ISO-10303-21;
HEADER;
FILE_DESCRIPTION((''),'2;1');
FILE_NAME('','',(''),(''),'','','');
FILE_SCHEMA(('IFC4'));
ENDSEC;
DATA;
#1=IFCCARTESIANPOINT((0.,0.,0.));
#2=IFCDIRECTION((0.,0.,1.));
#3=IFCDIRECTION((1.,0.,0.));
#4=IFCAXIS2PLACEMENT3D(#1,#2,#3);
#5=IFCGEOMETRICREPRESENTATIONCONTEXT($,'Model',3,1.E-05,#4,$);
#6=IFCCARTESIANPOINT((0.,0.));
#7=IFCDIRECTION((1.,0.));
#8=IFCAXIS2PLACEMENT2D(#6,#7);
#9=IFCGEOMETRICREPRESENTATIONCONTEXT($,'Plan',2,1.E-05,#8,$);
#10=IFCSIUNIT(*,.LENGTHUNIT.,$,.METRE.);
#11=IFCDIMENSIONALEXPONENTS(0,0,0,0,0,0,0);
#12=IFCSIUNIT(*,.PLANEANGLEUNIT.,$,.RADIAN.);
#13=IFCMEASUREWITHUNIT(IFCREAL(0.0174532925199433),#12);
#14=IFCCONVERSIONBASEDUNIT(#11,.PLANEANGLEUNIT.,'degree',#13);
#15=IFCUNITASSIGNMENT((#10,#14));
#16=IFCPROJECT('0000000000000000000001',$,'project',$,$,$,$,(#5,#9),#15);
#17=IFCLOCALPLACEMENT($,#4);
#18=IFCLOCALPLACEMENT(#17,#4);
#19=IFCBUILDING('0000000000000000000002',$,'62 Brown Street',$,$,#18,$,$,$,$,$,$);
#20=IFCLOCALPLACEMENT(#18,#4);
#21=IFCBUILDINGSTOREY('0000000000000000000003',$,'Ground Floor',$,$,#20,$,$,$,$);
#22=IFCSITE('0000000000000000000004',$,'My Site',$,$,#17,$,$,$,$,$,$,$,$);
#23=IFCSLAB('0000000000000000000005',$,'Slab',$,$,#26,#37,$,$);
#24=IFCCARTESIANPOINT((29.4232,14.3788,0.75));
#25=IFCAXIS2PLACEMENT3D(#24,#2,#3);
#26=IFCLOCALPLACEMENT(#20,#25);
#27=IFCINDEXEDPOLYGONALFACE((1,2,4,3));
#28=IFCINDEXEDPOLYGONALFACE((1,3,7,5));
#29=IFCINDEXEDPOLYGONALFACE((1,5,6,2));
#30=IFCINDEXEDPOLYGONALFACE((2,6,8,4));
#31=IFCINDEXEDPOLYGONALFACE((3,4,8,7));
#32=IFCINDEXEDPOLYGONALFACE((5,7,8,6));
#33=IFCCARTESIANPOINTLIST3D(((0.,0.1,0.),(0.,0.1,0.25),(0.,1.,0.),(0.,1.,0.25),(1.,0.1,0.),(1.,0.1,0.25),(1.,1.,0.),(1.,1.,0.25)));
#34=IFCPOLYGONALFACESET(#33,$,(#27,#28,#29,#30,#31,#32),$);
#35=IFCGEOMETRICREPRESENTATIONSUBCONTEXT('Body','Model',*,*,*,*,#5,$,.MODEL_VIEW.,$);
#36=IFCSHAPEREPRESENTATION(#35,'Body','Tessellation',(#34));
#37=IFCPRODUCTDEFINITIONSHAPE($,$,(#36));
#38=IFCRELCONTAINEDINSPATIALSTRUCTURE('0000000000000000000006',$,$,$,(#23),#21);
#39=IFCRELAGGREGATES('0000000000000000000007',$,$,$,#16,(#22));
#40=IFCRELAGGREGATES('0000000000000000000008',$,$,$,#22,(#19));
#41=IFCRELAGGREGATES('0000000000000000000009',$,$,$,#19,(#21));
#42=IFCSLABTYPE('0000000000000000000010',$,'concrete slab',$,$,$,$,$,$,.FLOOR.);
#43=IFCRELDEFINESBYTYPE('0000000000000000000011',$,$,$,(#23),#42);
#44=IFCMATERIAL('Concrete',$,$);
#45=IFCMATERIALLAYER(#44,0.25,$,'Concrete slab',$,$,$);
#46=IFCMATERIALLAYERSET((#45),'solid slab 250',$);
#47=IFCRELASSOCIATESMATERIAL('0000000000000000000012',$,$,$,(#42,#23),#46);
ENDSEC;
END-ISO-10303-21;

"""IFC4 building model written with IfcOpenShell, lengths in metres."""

from ifc_helpers import new_model, entity, si_unit, converted_unit, frame, origin_with_axes, origin_2d_with_axis, place, context, subcontext, project, spatial, line, indexed_curve, outline, extrude, material, layer, layer_set, layer_usage, type_object, element, save


model = new_model("IFC4")

# Units and contexts
model_context = context("Model", 3, precision=1e-05, world=origin_with_axes())
plan_context = context("Plan", 2, precision=1e-05, world=origin_2d_with_axis())
body_context_1 = subcontext(model_context, "Body", "Model", "MODEL_VIEW")
ifc_project = project(units=[si_unit("LENGTHUNIT", "METRE"), converted_unit("PLANEANGLEUNIT", "degree", entity("IfcReal", 0.0174532925199433), si_unit("PLANEANGLEUNIT", "RADIAN"), dimensions=[0, 0, 0, 0, 0, 0, 0])], contexts=[model_context, plan_context])

# Site, building, storey
site_placement = place(None, origin_with_axes())
site = spatial("IfcSite", under=ifc_project, at=site_placement, Name="My Site")
building_placement = place(site_placement, origin_with_axes())
building = spatial("IfcBuilding", under=site, at=building_placement, Name="62 Brown Street")
storey_placement = place(building_placement, origin_with_axes())
storey = spatial("IfcBuildingStorey", under=building, at=storey_placement, Name="Ground Floor")

# Shared definitions
ifc_material_1 = material(Name="Concrete")

# Slab
ifc_layer_1 = layer(ifc_material_1, 0.25, Name="Concrete slab")
ifc_layer_set_1 = layer_set([ifc_layer_1], Name="solid slab 250")
ifc_layer_usage_1 = layer_usage(ifc_layer_set_1, "AXIS3", "POSITIVE", 0.0)
slab_type = type_object("IfcSlabType", Name="concrete slab", PredefinedType="FLOOR", material=ifc_layer_set_1)
slab_placement = place(storey_placement, frame((29.4232, 14.3788, 0.75), z_axis=(0.0, 0.0, 1.0), x_axis=(1.0, 0.0, 0.0)))
element("IfcSlab", 1, at=slab_placement, inside=storey, type_object=slab_type, material=ifc_layer_usage_1, Name="Slab", context=body_context_1, shape_type="SweptSolid", body=[
    extrude(outline(indexed_curve([(1.0, 1.0), (1.0, 0.1), (0.0, 0.1), (0.0, 1.0)], segments=[line(3, 2), line(2, 1), line(1, 4), line(4, 3)], self_intersect=False)), None, (0.0, 0.0, 1.0), 0.25),
])

save(model, "model.ifc")
